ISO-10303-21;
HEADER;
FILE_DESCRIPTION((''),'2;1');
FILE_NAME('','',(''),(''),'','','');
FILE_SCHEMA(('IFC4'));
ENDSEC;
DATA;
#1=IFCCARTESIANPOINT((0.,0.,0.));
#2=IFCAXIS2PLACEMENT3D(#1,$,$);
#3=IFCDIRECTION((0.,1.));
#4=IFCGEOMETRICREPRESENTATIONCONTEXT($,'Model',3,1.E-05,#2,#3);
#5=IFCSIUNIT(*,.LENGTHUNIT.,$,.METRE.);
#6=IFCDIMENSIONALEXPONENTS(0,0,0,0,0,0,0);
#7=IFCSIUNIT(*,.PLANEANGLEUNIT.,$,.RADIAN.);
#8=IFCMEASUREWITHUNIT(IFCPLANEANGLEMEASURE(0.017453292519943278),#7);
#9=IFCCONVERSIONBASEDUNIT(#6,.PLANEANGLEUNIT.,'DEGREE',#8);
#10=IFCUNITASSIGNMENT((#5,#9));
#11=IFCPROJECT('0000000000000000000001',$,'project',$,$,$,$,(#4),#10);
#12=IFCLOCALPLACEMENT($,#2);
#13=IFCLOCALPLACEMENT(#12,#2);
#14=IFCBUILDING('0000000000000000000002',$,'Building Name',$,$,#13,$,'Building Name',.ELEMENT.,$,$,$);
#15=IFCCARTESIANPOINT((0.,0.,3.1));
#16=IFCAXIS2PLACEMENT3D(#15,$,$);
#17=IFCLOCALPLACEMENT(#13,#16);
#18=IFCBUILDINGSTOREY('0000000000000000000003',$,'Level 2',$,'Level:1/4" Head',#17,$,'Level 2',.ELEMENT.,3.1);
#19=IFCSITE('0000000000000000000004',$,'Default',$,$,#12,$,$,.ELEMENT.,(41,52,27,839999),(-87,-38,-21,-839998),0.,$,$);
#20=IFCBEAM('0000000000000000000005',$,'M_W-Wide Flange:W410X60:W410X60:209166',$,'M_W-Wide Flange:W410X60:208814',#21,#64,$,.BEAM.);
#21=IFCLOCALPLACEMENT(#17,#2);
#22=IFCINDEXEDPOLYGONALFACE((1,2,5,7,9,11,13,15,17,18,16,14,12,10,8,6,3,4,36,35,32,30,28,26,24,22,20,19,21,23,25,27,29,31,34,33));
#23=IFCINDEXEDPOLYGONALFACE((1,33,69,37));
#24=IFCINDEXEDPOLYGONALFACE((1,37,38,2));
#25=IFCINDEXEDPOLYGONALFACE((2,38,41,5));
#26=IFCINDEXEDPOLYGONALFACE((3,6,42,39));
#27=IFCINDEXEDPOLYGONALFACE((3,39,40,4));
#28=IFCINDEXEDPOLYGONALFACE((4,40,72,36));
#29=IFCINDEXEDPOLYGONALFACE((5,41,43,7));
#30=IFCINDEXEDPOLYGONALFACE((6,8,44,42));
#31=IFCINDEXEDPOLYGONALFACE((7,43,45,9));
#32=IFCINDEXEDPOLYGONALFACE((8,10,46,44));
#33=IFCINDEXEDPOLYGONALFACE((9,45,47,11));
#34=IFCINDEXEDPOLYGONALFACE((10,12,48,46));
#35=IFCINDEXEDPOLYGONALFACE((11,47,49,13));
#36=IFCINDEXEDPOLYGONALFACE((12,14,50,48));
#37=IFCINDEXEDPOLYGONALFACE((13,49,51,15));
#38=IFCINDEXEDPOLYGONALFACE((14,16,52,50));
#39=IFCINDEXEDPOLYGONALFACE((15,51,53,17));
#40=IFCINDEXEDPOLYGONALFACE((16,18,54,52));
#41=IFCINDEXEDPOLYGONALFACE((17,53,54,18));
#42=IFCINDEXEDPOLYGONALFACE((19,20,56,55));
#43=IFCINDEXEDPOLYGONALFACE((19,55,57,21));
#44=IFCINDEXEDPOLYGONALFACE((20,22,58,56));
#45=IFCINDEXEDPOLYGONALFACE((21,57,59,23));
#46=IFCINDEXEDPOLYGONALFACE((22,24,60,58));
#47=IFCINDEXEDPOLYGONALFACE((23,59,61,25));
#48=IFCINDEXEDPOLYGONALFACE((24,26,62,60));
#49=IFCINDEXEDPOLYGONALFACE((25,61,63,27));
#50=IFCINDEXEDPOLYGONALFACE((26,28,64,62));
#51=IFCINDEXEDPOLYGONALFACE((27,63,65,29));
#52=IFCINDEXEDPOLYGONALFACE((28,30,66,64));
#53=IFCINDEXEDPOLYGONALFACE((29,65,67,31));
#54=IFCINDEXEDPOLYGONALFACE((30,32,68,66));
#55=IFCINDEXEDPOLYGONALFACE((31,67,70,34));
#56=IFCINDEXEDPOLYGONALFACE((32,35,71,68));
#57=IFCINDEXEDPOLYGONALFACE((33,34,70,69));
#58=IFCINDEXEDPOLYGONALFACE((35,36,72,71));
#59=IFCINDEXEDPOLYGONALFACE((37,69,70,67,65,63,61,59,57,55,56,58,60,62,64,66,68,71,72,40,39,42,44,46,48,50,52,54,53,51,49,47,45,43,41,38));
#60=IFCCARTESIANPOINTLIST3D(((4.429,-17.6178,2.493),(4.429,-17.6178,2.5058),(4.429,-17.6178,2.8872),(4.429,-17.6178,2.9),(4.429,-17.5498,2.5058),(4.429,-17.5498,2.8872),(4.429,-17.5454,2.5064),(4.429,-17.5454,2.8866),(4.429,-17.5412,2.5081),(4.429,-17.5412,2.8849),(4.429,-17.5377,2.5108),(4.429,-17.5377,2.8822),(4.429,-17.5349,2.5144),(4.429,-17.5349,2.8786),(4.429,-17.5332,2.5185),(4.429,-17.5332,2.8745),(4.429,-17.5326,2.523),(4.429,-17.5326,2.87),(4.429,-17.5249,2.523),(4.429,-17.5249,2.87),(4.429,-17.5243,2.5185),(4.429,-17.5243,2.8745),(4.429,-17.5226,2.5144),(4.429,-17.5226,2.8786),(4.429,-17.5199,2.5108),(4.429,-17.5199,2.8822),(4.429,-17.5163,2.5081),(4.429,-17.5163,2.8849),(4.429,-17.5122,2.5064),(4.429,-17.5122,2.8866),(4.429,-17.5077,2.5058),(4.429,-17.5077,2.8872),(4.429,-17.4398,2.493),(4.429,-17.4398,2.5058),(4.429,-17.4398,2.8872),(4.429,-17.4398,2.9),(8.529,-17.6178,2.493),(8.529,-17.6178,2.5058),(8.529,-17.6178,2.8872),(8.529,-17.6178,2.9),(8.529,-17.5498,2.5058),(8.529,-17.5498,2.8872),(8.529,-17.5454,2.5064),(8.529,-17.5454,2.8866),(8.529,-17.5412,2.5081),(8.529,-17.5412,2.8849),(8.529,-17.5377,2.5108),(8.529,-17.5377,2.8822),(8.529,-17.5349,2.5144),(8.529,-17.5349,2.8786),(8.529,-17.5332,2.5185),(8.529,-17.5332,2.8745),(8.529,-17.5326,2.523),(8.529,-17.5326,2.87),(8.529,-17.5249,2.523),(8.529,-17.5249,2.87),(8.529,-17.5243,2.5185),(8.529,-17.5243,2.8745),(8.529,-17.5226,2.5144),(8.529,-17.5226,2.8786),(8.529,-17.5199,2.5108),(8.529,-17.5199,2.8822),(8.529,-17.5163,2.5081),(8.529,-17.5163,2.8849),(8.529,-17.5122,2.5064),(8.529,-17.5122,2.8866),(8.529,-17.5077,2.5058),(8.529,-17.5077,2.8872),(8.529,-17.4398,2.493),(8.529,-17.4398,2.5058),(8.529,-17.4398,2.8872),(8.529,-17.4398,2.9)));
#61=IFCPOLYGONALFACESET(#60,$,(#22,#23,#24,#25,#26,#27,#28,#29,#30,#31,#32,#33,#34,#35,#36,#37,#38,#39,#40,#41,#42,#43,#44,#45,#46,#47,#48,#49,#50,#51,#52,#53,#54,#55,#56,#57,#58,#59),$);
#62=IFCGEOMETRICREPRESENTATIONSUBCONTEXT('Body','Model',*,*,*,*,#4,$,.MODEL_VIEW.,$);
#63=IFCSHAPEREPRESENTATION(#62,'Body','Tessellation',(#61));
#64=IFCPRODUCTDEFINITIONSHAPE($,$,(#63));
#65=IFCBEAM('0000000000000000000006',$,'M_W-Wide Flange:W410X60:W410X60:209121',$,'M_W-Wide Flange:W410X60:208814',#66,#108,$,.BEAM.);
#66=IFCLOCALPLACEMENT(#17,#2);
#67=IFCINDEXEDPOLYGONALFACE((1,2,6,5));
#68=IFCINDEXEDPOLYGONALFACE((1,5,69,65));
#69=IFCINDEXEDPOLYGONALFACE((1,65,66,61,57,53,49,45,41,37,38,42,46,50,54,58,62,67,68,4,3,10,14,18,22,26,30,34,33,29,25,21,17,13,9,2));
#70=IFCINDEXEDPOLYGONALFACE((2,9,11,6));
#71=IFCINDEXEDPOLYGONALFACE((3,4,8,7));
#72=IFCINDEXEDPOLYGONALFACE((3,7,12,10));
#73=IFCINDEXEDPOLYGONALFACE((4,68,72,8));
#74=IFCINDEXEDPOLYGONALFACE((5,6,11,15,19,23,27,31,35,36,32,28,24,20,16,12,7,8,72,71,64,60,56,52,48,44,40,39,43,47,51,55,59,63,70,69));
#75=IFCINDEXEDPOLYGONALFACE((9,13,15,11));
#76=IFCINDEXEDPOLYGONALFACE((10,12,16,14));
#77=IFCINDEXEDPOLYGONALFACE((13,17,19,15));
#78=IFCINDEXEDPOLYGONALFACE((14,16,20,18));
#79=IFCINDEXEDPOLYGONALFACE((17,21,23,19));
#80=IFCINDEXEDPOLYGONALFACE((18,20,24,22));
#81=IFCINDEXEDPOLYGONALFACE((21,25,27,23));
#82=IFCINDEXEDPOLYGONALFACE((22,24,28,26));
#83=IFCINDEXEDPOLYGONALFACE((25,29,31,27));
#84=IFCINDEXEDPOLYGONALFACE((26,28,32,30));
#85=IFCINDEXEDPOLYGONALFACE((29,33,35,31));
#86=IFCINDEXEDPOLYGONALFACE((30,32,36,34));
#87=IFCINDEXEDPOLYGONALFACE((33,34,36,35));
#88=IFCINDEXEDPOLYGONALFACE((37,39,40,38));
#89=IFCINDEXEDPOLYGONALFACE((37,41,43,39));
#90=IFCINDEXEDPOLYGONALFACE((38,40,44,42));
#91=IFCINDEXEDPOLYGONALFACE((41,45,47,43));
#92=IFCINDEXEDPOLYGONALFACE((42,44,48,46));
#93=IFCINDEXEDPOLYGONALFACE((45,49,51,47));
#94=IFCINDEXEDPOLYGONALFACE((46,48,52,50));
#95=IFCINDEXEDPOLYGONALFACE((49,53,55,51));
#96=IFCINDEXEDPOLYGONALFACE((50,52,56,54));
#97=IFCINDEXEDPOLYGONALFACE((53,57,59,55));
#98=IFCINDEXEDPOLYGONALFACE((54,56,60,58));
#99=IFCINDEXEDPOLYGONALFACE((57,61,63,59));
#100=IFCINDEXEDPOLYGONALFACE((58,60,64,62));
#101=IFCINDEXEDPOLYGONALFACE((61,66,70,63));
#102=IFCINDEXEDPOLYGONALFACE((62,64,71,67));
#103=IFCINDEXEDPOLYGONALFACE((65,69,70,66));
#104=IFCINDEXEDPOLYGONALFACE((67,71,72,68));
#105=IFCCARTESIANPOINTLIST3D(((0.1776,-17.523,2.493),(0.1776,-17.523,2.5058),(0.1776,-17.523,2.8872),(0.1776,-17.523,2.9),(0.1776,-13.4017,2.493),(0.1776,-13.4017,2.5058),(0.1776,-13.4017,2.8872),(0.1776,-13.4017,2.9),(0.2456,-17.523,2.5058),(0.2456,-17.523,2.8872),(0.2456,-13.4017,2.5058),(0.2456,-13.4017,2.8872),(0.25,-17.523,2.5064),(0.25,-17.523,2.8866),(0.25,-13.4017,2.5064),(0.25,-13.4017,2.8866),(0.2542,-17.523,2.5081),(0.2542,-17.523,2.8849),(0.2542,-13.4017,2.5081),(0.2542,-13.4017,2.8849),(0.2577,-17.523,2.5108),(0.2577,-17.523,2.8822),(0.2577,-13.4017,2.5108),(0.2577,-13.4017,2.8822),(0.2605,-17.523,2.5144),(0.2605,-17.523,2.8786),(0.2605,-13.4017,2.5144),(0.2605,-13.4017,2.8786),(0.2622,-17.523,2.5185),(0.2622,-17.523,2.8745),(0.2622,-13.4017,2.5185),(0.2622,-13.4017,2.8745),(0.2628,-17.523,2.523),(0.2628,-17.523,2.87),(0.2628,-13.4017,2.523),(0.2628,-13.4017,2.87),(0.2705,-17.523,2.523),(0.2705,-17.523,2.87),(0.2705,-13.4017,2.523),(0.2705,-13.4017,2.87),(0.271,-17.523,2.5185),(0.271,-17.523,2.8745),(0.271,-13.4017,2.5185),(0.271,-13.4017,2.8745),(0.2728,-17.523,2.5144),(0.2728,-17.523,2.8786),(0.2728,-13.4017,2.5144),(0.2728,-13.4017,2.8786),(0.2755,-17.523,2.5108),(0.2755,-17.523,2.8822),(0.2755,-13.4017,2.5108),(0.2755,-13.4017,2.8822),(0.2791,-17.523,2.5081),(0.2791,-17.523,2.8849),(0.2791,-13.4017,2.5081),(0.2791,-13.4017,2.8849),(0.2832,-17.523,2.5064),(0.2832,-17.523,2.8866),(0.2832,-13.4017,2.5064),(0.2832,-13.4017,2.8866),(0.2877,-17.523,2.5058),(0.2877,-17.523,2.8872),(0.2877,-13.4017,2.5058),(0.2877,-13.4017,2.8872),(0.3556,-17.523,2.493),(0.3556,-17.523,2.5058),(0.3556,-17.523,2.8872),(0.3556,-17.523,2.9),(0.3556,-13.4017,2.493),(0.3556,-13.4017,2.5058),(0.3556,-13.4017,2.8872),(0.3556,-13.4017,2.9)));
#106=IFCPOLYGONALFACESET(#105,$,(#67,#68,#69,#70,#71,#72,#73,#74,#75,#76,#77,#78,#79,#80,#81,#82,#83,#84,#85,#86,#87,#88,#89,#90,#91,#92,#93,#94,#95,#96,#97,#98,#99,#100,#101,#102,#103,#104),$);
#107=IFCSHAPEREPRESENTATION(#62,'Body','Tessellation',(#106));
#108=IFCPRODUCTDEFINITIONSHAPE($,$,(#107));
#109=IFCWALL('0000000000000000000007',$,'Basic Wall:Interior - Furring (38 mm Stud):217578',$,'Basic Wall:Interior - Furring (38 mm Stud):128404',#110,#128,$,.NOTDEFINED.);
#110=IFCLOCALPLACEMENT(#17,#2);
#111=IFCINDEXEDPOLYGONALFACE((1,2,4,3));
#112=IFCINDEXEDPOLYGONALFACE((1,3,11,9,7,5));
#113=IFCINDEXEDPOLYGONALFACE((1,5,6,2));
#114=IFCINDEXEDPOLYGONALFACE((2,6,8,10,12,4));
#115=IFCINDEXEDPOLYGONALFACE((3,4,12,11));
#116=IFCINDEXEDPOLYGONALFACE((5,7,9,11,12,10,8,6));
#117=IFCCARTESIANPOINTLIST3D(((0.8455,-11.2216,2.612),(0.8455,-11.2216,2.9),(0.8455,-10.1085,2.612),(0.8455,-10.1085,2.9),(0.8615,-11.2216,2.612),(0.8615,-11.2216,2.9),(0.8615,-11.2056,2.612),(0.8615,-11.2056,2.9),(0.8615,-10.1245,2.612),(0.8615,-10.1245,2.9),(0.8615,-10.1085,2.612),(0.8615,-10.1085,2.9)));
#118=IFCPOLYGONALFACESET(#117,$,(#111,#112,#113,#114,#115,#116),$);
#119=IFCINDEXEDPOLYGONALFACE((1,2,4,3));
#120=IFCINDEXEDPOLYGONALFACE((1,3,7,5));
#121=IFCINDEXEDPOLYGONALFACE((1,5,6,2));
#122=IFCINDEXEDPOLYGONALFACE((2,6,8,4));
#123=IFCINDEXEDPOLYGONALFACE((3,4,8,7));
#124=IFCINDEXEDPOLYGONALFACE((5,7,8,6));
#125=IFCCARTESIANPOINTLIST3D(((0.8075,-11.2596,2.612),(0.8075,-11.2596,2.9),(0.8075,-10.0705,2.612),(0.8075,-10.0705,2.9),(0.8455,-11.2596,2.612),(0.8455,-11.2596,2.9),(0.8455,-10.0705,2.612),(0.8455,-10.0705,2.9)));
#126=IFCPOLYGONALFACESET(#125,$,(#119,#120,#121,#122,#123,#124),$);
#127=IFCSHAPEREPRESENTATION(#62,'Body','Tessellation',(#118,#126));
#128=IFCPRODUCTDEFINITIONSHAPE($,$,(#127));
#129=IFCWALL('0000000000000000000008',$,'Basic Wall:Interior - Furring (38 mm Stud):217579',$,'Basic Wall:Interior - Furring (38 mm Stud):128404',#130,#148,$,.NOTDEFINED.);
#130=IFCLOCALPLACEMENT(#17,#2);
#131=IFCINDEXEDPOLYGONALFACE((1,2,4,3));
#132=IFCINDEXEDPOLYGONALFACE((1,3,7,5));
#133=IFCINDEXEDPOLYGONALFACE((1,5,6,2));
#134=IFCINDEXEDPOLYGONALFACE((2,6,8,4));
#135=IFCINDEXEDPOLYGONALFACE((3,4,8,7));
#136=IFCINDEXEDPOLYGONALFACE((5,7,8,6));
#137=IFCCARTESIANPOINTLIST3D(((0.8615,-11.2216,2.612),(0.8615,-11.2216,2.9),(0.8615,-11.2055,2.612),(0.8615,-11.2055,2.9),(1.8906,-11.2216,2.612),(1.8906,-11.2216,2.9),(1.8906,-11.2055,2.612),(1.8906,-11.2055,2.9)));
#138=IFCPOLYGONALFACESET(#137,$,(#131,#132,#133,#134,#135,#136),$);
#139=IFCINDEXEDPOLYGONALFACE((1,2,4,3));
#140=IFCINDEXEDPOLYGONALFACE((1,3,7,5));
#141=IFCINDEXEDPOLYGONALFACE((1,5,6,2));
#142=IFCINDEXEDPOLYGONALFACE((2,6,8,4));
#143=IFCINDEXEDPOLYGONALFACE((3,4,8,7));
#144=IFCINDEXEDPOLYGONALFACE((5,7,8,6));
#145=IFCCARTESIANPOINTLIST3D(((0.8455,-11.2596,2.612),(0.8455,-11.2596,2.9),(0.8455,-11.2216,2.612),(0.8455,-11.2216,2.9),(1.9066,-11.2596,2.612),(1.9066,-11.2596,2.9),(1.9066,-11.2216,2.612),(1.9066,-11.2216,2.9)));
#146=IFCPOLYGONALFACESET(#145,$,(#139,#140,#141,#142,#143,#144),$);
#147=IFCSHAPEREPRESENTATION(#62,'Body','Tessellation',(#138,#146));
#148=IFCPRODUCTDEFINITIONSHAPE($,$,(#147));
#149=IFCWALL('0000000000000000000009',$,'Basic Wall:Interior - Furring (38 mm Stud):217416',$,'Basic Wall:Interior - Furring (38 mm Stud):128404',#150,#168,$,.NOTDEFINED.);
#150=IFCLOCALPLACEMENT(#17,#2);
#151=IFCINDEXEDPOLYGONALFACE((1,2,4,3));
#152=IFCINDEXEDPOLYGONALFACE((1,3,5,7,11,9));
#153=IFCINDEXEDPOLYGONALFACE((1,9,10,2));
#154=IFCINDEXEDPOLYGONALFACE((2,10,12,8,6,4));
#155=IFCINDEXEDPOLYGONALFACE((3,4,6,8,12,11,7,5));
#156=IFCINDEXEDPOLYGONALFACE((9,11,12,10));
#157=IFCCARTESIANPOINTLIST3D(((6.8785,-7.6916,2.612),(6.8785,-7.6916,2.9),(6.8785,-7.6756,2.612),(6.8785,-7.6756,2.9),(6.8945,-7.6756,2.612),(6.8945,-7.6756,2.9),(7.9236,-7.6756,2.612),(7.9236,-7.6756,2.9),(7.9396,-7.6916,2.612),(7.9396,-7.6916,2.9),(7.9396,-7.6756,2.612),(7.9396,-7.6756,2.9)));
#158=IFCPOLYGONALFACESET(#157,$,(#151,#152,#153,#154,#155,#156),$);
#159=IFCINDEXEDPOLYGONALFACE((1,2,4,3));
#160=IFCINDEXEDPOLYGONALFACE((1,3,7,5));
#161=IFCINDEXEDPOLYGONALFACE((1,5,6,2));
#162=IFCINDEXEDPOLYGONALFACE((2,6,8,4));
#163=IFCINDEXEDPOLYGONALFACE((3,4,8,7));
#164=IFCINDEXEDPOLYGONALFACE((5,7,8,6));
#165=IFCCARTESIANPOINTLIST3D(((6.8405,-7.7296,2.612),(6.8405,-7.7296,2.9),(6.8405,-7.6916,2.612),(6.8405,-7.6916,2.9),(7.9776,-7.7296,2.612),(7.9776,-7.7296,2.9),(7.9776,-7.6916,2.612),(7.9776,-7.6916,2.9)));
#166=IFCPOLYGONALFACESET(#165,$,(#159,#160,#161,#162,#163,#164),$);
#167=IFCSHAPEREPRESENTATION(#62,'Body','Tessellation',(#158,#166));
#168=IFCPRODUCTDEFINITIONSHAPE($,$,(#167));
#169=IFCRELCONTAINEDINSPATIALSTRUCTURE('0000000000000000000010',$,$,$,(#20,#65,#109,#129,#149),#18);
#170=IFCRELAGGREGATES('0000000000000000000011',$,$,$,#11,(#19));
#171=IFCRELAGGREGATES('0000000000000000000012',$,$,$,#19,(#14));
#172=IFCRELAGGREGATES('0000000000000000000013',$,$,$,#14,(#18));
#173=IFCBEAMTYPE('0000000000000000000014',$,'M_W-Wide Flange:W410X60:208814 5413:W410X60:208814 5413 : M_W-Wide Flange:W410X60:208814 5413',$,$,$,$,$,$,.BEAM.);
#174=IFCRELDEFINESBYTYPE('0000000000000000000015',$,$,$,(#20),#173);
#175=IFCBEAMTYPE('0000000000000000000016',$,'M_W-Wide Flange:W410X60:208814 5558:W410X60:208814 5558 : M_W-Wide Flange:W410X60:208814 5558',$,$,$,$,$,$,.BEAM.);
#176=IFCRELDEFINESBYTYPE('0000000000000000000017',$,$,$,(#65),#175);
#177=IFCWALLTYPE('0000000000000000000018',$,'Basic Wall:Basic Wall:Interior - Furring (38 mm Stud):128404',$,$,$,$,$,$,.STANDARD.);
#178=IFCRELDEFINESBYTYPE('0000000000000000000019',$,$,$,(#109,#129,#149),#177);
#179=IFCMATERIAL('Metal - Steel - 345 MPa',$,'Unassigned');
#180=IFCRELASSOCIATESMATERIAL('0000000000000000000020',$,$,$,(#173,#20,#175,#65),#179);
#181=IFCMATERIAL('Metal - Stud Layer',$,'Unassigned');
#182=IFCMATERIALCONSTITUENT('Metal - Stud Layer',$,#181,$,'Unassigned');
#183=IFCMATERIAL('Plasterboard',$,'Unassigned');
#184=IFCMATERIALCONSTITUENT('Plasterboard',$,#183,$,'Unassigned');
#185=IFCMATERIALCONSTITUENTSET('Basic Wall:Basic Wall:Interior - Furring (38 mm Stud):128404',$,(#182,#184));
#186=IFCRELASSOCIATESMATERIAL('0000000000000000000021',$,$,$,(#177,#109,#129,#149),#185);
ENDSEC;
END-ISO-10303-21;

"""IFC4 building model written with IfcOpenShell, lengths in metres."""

from ifc_helpers import new_model, entity, si_unit, converted_unit, direction, frame, origin, place, context, subcontext, project, spatial, line, arc, indexed_curve, outline, extrude, source, transform, mapped, material, constituent, constituent_set, type_object, type_shapes, element, save


model = new_model("IFC4")

# Units and contexts
model_context = context("Model", 3, precision=1e-05, world=origin(), true_north=direction((0.0, 1.0)))
body_context = subcontext(model_context, "Body", "Model", "MODEL_VIEW")
ifc_project = project(units=[si_unit("LENGTHUNIT", "METRE"), converted_unit("PLANEANGLEUNIT", "DEGREE", entity("IfcPlaneAngleMeasure", 0.017453292519943278), si_unit("PLANEANGLEUNIT", "RADIAN"), dimensions=[0, 0, 0, 0, 0, 0, 0])], contexts=[model_context])

# Site, building, storey
site_placement = place(None, origin())
site = spatial("IfcSite", under=ifc_project, at=site_placement, Name="Default", CompositionType="ELEMENT", RefLatitude=(41, 52, 27, 839999), RefLongitude=(-87, -38, -21, -839998), RefElevation=0.0)
building_placement = place(site_placement, origin())
building = spatial("IfcBuilding", under=site, at=building_placement, Name="Building Name", LongName="Building Name", CompositionType="ELEMENT")
storey_placement = place(building_placement, frame((0.0, 0.0, 3.1)))
storey = spatial("IfcBuildingStorey", under=building, at=storey_placement, Name="Level 2", ObjectType="Level:1/4\" Head", LongName="Level 2", CompositionType="ELEMENT", Elevation=3.1)

# Beams
ifc_material_1 = material(Name="Metal - Steel - 345 MPa", Category="Unassigned")
beam_type_1 = type_object("IfcBeamType", Name="M_W-Wide Flange:W410X60:208814 5413:W410X60:208814 5413 : M_W-Wide Flange:W410X60:208814 5413", PredefinedType="BEAM", material=ifc_material_1)
shared_shape_1 = source(origin(), body_context, "Body", "SweptSolid", [
    extrude(outline(indexed_curve([(-0.0211, -0.1907), (-0.089, -0.1907), (-0.089, -0.2035), (0.089, -0.2035), (0.089, -0.1907), (0.0211, -0.1907), (0.0089, -0.1857), (0.0039, -0.1735), (0.0039, 0.1735), (0.0089, 0.1857), (0.0211, 0.1907), (0.089, 0.1907), (0.089, 0.2035), (-0.089, 0.2035), (-0.089, 0.1907), (-0.0211, 0.1907), (-0.0089, 0.1857), (-0.0039, 0.1735), (-0.0039, -0.1735), (-0.0089, -0.1857)], segments=[line(1, 2, 3, 4, 5, 6), arc(6, 7, 8), line(8, 9), arc(9, 10, 11), line(11, 12, 13, 14, 15, 16), arc(16, 17, 18), line(18, 19), arc(19, 20, 1)], self_intersect=False)), frame((0.0, 0.0, -0.2035), z_axis=(0.0, -1.0, 0.0), x_axis=(1.0, 0.0, 0.0)), (0.0, 0.0, -1.0), 4.1),
])
type_shapes(beam_type_1, [shared_shape_1])
beam_1_placement = place(storey_placement, frame((4.429, -17.5288, 2.9), z_axis=(0.0, 0.0, 1.0), x_axis=(0.0, -1.0, 0.0)))
element("IfcBeam", 1, at=beam_1_placement, inside=storey, type_object=beam_type_1, material=ifc_material_1, Name="M_W-Wide Flange:W410X60:W410X60:209166", ObjectType="M_W-Wide Flange:W410X60:208814", PredefinedType="BEAM", context=body_context, shape_type="MappedRepresentation", body=[
    mapped(shared_shape_1, transform((0.0, 0.0, 0.0), scale=1.0)),
])
beam_type_2 = type_object("IfcBeamType", Name="M_W-Wide Flange:W410X60:208814 5558:W410X60:208814 5558 : M_W-Wide Flange:W410X60:208814 5558", PredefinedType="BEAM", material=ifc_material_1)
shared_shape_2 = source(origin(), body_context, "Body", "SweptSolid", [
    extrude(outline(indexed_curve([(-0.2035, -0.089), (-0.1907, -0.089), (-0.1907, -0.0211), (-0.1857, -0.0089), (-0.1735, -0.0039), (0.1735, -0.0039), (0.1857, -0.0089), (0.1907, -0.0211), (0.1907, -0.089), (0.2035, -0.089), (0.2035, 0.089), (0.1907, 0.089), (0.1907, 0.021), (0.1857, 0.0089), (0.1735, 0.0038), (-0.1735, 0.0038), (-0.1857, 0.0089), (-0.1907, 0.021), (-0.1907, 0.089), (-0.2035, 0.089)], segments=[line(1, 2, 3), arc(3, 4, 5), line(5, 6), arc(6, 7, 8), line(8, 9, 10, 11, 12, 13), arc(13, 14, 15), line(15, 16), arc(16, 17, 18), line(18, 19, 20, 1)], self_intersect=False)), frame((0.0, 0.0, -0.2035), z_axis=(0.0, 1.0, 0.0), x_axis=(0.0, 0.0, 1.0)), (0.0, 0.0, 1.0), 4.1213),
])
type_shapes(beam_type_2, [shared_shape_2])
beam_2_placement = place(storey_placement, frame((0.2666, -13.4017, 2.9), z_axis=(0.0, 0.0, 1.0), x_axis=(-1.0, 0.0, 0.0)))
element("IfcBeam", 2, at=beam_2_placement, inside=storey, type_object=beam_type_2, material=ifc_material_1, Name="M_W-Wide Flange:W410X60:W410X60:209121", ObjectType="M_W-Wide Flange:W410X60:208814", PredefinedType="BEAM", context=body_context, shape_type="MappedRepresentation", body=[
    mapped(shared_shape_2, transform((0.0, 0.0, 0.0), scale=1.0)),
])

# Shared definitions
ifc_material_2 = material(Name="Plasterboard", Category="Unassigned")
ifc_material_3 = material(Name="Metal - Stud Layer", Category="Unassigned")

# Walls
ifc_constituent_1 = constituent(ifc_material_3, Name="Metal - Stud Layer", Category="Unassigned")
ifc_constituent_2 = constituent(ifc_material_2, Name="Plasterboard", Category="Unassigned")
ifc_constituent_set_1 = constituent_set(constituents=[ifc_constituent_1, ifc_constituent_2], Name="Basic Wall:Basic Wall:Interior - Furring (38 mm Stud):128404")
wall_type_1 = type_object("IfcWallType", Name="Basic Wall:Basic Wall:Interior - Furring (38 mm Stud):128404", PredefinedType="STANDARD", material=ifc_constituent_set_1)
wall_1_placement = place(storey_placement, frame((0.8345, -11.2596, 2.612), z_axis=(0.0, 0.0, 1.0), x_axis=(0.0, 1.0, 0.0)))
element("IfcWall", 3, at=wall_1_placement, inside=storey, type_object=wall_type_1, material=ifc_constituent_set_1, Name="Basic Wall:Interior - Furring (38 mm Stud):217578", ObjectType="Basic Wall:Interior - Furring (38 mm Stud):128404", PredefinedType="NOTDEFINED", context=body_context, shape_type="SweptSolid", body=[
    extrude(outline(indexed_curve([(-0.5405, -0.0053), (0.5405, -0.0053), (0.5565, -0.0053), (0.5565, 0.0107), (-0.5565, 0.0107), (-0.5565, -0.0053), (-0.5405, -0.0053)], self_intersect=False)), frame((0.5945, -0.0217, 0.0)), (0.0, 0.0, 1.0), 0.288),
    extrude(outline(indexed_curve([(-0.019, -0.5945), (0.019, -0.5945), (0.019, 0.5945), (-0.019, 0.5945), (-0.019, -0.5945)], self_intersect=False)), frame((0.5945, 0.008, 0.0), z_axis=(0.0, 0.0, 1.0), x_axis=(0.0, -1.0, 0.0)), (0.0, 0.0, 1.0), 0.288),
])
wall_2_placement = place(storey_placement, frame((1.8906, -11.2325, 2.612), z_axis=(0.0, 0.0, 1.0), x_axis=(-1.0, 0.0, 0.0)))
element("IfcWall", 4, at=wall_2_placement, inside=storey, type_object=wall_type_1, material=ifc_constituent_set_1, Name="Basic Wall:Interior - Furring (38 mm Stud):217579", ObjectType="Basic Wall:Interior - Furring (38 mm Stud):128404", PredefinedType="NOTDEFINED", context=body_context, shape_type="SweptSolid", body=[
    extrude(outline(indexed_curve([(-0.008, -0.5145), (0.008, -0.5145), (0.008, 0.5145), (-0.008, 0.5145), (-0.008, -0.5145)], self_intersect=False)), frame((0.5145, -0.019, 0.0), z_axis=(0.0, 0.0, 1.0), x_axis=(0.0, 1.0, 0.0)), (0.0, 0.0, 1.0), 0.288),
    extrude(outline(indexed_curve([(-0.019, -0.5305), (0.019, -0.5305), (0.019, 0.5305), (-0.019, 0.5305), (-0.019, -0.5305)], self_intersect=False)), frame((0.5145, 0.008, 0.0), z_axis=(0.0, 0.0, 1.0), x_axis=(0.0, -1.0, 0.0)), (0.0, 0.0, 1.0), 0.288),
])
wall_3_placement = place(storey_placement, frame((7.9776, -7.7026, 2.612), z_axis=(0.0, 0.0, 1.0), x_axis=(-1.0, 0.0, 0.0)))
element("IfcWall", 5, at=wall_3_placement, inside=storey, type_object=wall_type_1, material=ifc_constituent_set_1, Name="Basic Wall:Interior - Furring (38 mm Stud):217416", ObjectType="Basic Wall:Interior - Furring (38 mm Stud):128404", PredefinedType="NOTDEFINED", context=body_context, shape_type="SweptSolid", body=[
    extrude(outline(indexed_curve([(-0.5146, -0.0053), (0.5145, -0.0053), (0.5305, -0.0053), (0.5305, 0.0107), (-0.5306, 0.0107), (-0.5306, -0.0053), (-0.5146, -0.0053)], self_intersect=False)), frame((0.5686, -0.0217, 0.0)), (0.0, 0.0, 1.0), 0.288),
    extrude(outline(indexed_curve([(-0.019, -0.5685), (0.019, -0.5685), (0.019, 0.5685), (-0.019, 0.5685), (-0.019, -0.5685)], self_intersect=False)), frame((0.5685, 0.008, 0.0), z_axis=(0.0, 0.0, 1.0), x_axis=(0.0, -1.0, 0.0)), (0.0, 0.0, 1.0), 0.288),
])

save(model, "model.ifc")
